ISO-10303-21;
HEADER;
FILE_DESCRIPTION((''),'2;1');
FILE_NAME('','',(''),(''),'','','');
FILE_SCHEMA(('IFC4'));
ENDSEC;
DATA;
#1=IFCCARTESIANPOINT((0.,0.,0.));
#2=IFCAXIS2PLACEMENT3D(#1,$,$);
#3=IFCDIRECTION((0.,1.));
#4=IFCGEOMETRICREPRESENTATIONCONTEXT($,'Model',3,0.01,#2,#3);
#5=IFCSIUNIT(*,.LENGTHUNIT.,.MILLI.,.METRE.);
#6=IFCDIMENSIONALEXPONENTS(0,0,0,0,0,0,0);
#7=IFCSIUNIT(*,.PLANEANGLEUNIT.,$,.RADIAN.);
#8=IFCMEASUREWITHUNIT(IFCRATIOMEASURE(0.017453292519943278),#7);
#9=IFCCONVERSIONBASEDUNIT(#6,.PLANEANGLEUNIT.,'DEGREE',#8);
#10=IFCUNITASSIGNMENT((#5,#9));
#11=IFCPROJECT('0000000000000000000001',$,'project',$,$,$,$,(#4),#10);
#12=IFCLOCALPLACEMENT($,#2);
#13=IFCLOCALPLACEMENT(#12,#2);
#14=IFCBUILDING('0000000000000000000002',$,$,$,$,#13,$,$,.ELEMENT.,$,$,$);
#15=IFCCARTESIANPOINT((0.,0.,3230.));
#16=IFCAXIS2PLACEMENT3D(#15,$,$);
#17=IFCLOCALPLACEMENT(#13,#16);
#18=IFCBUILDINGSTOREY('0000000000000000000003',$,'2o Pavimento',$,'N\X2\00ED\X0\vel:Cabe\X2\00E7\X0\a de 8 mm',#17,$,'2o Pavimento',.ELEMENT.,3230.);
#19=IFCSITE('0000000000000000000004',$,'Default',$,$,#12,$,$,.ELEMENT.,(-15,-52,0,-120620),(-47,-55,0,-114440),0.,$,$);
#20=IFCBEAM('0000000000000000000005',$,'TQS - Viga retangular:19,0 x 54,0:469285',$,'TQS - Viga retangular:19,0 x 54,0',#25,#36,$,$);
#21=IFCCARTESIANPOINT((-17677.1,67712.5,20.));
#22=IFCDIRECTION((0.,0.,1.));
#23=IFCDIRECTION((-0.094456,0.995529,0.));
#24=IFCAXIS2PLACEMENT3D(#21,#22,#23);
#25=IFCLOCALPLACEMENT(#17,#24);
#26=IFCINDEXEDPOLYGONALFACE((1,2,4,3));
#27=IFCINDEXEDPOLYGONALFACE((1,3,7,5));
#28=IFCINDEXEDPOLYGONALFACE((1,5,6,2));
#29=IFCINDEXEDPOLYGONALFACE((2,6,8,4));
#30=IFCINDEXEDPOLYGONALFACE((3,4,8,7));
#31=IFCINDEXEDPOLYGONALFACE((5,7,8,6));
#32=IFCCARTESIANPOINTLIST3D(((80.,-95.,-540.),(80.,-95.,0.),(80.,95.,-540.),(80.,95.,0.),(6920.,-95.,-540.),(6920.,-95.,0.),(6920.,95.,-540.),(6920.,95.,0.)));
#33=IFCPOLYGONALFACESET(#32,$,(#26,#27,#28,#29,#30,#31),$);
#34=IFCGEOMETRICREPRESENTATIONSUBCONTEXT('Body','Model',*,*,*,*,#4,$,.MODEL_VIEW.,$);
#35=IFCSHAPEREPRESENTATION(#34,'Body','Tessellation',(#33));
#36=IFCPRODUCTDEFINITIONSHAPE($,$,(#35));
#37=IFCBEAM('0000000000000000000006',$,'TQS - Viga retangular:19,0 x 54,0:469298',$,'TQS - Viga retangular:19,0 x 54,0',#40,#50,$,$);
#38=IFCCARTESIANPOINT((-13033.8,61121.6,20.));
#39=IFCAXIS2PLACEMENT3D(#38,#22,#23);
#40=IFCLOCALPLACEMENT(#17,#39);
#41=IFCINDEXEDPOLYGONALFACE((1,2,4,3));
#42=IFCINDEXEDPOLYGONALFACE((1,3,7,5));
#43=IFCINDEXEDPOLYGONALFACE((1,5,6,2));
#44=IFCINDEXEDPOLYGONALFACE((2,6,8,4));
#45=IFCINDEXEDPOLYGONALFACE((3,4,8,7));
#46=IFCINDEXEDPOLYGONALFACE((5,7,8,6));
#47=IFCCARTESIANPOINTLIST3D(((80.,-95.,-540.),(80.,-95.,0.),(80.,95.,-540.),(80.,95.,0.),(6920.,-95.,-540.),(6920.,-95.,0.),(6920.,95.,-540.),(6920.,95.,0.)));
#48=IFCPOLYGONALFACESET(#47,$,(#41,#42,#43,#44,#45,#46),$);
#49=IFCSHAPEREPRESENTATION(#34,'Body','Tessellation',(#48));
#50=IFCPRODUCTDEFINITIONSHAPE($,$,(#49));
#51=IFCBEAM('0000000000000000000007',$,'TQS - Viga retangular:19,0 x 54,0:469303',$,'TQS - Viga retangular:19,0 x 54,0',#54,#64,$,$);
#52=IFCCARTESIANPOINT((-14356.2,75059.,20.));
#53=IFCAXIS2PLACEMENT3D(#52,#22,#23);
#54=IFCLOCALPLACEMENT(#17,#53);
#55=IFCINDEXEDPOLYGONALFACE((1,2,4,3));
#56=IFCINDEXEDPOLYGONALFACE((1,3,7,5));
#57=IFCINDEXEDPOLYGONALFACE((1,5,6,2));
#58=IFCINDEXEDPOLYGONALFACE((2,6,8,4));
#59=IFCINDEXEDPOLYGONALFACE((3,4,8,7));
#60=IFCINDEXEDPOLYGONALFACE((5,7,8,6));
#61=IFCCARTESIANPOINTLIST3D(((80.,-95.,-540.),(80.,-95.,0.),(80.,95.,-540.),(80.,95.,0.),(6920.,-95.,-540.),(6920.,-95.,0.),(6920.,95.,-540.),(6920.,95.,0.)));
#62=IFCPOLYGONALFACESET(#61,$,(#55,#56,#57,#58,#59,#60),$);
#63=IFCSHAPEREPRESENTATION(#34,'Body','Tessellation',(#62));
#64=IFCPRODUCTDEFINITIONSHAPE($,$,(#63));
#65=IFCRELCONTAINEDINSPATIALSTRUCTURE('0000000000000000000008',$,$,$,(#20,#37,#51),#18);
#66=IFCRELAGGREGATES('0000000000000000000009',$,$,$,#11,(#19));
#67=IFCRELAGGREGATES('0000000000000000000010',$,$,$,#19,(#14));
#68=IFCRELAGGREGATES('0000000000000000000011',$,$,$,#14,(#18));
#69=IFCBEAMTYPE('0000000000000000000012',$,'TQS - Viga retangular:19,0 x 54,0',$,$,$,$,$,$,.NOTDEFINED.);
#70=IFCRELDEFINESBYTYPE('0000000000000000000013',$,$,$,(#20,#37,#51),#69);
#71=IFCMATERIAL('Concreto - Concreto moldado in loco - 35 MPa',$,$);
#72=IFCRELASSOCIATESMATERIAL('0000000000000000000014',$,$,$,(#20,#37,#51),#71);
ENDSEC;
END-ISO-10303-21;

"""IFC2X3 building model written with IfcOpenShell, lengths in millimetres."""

from ifc_helpers import new_model, entity, si_unit, converted_unit, direction, frame, frame_2d, origin, place, context, subcontext, project, spatial, rectangle, extrude, material, type_object, element, save


model = new_model("IFC2X3")

# Units and contexts
model_context = context("Model", 3, precision=0.01, world=origin(), true_north=direction((0.0, 1.0)))
body_context = subcontext(model_context, "Body", "Model", "MODEL_VIEW")
ifc_project = project(units=[si_unit("LENGTHUNIT", "METRE", prefix="MILLI"), converted_unit("PLANEANGLEUNIT", "DEGREE", entity("IfcRatioMeasure", 0.017453292519943278), si_unit("PLANEANGLEUNIT", "RADIAN"), dimensions=[0, 0, 0, 0, 0, 0, 0])], contexts=[model_context])

# Site, building, storey
site_placement = place(None, origin())
site = spatial("IfcSite", under=ifc_project, at=site_placement, Name="Default", CompositionType="ELEMENT", RefLatitude=(-15, -52, 0, -120620), RefLongitude=(-47, -55, 0, -114440), RefElevation=0.0)
building_placement = place(site_placement, origin())
building = spatial("IfcBuilding", under=site, at=building_placement, CompositionType="ELEMENT")
storey_placement = place(building_placement, frame((0.0, 0.0, 3230.0)))
storey = spatial("IfcBuildingStorey", under=building, at=storey_placement, Name="2o Pavimento", ObjectType="Nível:Cabeça de 8 mm", LongName="2o Pavimento", CompositionType="ELEMENT", Elevation=3230.0)

# Beams
ifc_material = material(Name="Concreto - Concreto moldado in loco - 35 MPa")
beam_type_1 = type_object("IfcBeamType", Name="TQS - Viga retangular:19,0 x 54,0", PredefinedType="NOTDEFINED")
beam_1_placement = place(storey_placement, frame((-17677.1, 67712.5, 20.0), z_axis=(0.0, 0.0, 1.0), x_axis=(-0.094456, 0.995529, 0.0)))
element("IfcBeam", 1, at=beam_1_placement, inside=storey, type_object=beam_type_1, material=ifc_material, Name="TQS - Viga retangular:19,0 x 54,0:469285", ObjectType="TQS - Viga retangular:19,0 x 54,0", context=body_context, shape_type="SweptSolid", body=[
    extrude(rectangle(XDim=540.0, YDim=190.0, at=frame_2d((0.0, 0.0), x_axis=(1.0, 0.0))), frame((80.0, 0.0, -270.0), z_axis=(1.0, 0.0, 0.0), x_axis=(0.0, 0.0, -1.0)), (0.0, 0.0, 1.0), 6840.0),
])
beam_2_placement = place(storey_placement, frame((-13033.8, 61121.6, 20.0), z_axis=(0.0, 0.0, 1.0), x_axis=(-0.094456, 0.995529, 0.0)))
element("IfcBeam", 2, at=beam_2_placement, inside=storey, type_object=beam_type_1, material=ifc_material, Name="TQS - Viga retangular:19,0 x 54,0:469298", ObjectType="TQS - Viga retangular:19,0 x 54,0", context=body_context, shape_type="SweptSolid", body=[
    extrude(rectangle(XDim=540.0, YDim=190.0, at=frame_2d((0.0, 0.0), x_axis=(1.0, 0.0))), frame((80.0, 0.0, -270.0), z_axis=(1.0, 0.0, 0.0), x_axis=(0.0, 0.0, -1.0)), (0.0, 0.0, 1.0), 6840.0),
])
beam_3_placement = place(storey_placement, frame((-14356.2, 75059.0, 20.0), z_axis=(0.0, 0.0, 1.0), x_axis=(-0.094456, 0.995529, 0.0)))
element("IfcBeam", 3, at=beam_3_placement, inside=storey, type_object=beam_type_1, material=ifc_material, Name="TQS - Viga retangular:19,0 x 54,0:469303", ObjectType="TQS - Viga retangular:19,0 x 54,0", context=body_context, shape_type="SweptSolid", body=[
    extrude(rectangle(XDim=540.0, YDim=190.0, at=frame_2d((0.0, 0.0), x_axis=(1.0, 0.0))), frame((80.0, 0.0, -270.0), z_axis=(1.0, 0.0, 0.0), x_axis=(0.0, 0.0, -1.0)), (0.0, 0.0, 1.0), 6840.0),
])

save(model, "model.ifc")
